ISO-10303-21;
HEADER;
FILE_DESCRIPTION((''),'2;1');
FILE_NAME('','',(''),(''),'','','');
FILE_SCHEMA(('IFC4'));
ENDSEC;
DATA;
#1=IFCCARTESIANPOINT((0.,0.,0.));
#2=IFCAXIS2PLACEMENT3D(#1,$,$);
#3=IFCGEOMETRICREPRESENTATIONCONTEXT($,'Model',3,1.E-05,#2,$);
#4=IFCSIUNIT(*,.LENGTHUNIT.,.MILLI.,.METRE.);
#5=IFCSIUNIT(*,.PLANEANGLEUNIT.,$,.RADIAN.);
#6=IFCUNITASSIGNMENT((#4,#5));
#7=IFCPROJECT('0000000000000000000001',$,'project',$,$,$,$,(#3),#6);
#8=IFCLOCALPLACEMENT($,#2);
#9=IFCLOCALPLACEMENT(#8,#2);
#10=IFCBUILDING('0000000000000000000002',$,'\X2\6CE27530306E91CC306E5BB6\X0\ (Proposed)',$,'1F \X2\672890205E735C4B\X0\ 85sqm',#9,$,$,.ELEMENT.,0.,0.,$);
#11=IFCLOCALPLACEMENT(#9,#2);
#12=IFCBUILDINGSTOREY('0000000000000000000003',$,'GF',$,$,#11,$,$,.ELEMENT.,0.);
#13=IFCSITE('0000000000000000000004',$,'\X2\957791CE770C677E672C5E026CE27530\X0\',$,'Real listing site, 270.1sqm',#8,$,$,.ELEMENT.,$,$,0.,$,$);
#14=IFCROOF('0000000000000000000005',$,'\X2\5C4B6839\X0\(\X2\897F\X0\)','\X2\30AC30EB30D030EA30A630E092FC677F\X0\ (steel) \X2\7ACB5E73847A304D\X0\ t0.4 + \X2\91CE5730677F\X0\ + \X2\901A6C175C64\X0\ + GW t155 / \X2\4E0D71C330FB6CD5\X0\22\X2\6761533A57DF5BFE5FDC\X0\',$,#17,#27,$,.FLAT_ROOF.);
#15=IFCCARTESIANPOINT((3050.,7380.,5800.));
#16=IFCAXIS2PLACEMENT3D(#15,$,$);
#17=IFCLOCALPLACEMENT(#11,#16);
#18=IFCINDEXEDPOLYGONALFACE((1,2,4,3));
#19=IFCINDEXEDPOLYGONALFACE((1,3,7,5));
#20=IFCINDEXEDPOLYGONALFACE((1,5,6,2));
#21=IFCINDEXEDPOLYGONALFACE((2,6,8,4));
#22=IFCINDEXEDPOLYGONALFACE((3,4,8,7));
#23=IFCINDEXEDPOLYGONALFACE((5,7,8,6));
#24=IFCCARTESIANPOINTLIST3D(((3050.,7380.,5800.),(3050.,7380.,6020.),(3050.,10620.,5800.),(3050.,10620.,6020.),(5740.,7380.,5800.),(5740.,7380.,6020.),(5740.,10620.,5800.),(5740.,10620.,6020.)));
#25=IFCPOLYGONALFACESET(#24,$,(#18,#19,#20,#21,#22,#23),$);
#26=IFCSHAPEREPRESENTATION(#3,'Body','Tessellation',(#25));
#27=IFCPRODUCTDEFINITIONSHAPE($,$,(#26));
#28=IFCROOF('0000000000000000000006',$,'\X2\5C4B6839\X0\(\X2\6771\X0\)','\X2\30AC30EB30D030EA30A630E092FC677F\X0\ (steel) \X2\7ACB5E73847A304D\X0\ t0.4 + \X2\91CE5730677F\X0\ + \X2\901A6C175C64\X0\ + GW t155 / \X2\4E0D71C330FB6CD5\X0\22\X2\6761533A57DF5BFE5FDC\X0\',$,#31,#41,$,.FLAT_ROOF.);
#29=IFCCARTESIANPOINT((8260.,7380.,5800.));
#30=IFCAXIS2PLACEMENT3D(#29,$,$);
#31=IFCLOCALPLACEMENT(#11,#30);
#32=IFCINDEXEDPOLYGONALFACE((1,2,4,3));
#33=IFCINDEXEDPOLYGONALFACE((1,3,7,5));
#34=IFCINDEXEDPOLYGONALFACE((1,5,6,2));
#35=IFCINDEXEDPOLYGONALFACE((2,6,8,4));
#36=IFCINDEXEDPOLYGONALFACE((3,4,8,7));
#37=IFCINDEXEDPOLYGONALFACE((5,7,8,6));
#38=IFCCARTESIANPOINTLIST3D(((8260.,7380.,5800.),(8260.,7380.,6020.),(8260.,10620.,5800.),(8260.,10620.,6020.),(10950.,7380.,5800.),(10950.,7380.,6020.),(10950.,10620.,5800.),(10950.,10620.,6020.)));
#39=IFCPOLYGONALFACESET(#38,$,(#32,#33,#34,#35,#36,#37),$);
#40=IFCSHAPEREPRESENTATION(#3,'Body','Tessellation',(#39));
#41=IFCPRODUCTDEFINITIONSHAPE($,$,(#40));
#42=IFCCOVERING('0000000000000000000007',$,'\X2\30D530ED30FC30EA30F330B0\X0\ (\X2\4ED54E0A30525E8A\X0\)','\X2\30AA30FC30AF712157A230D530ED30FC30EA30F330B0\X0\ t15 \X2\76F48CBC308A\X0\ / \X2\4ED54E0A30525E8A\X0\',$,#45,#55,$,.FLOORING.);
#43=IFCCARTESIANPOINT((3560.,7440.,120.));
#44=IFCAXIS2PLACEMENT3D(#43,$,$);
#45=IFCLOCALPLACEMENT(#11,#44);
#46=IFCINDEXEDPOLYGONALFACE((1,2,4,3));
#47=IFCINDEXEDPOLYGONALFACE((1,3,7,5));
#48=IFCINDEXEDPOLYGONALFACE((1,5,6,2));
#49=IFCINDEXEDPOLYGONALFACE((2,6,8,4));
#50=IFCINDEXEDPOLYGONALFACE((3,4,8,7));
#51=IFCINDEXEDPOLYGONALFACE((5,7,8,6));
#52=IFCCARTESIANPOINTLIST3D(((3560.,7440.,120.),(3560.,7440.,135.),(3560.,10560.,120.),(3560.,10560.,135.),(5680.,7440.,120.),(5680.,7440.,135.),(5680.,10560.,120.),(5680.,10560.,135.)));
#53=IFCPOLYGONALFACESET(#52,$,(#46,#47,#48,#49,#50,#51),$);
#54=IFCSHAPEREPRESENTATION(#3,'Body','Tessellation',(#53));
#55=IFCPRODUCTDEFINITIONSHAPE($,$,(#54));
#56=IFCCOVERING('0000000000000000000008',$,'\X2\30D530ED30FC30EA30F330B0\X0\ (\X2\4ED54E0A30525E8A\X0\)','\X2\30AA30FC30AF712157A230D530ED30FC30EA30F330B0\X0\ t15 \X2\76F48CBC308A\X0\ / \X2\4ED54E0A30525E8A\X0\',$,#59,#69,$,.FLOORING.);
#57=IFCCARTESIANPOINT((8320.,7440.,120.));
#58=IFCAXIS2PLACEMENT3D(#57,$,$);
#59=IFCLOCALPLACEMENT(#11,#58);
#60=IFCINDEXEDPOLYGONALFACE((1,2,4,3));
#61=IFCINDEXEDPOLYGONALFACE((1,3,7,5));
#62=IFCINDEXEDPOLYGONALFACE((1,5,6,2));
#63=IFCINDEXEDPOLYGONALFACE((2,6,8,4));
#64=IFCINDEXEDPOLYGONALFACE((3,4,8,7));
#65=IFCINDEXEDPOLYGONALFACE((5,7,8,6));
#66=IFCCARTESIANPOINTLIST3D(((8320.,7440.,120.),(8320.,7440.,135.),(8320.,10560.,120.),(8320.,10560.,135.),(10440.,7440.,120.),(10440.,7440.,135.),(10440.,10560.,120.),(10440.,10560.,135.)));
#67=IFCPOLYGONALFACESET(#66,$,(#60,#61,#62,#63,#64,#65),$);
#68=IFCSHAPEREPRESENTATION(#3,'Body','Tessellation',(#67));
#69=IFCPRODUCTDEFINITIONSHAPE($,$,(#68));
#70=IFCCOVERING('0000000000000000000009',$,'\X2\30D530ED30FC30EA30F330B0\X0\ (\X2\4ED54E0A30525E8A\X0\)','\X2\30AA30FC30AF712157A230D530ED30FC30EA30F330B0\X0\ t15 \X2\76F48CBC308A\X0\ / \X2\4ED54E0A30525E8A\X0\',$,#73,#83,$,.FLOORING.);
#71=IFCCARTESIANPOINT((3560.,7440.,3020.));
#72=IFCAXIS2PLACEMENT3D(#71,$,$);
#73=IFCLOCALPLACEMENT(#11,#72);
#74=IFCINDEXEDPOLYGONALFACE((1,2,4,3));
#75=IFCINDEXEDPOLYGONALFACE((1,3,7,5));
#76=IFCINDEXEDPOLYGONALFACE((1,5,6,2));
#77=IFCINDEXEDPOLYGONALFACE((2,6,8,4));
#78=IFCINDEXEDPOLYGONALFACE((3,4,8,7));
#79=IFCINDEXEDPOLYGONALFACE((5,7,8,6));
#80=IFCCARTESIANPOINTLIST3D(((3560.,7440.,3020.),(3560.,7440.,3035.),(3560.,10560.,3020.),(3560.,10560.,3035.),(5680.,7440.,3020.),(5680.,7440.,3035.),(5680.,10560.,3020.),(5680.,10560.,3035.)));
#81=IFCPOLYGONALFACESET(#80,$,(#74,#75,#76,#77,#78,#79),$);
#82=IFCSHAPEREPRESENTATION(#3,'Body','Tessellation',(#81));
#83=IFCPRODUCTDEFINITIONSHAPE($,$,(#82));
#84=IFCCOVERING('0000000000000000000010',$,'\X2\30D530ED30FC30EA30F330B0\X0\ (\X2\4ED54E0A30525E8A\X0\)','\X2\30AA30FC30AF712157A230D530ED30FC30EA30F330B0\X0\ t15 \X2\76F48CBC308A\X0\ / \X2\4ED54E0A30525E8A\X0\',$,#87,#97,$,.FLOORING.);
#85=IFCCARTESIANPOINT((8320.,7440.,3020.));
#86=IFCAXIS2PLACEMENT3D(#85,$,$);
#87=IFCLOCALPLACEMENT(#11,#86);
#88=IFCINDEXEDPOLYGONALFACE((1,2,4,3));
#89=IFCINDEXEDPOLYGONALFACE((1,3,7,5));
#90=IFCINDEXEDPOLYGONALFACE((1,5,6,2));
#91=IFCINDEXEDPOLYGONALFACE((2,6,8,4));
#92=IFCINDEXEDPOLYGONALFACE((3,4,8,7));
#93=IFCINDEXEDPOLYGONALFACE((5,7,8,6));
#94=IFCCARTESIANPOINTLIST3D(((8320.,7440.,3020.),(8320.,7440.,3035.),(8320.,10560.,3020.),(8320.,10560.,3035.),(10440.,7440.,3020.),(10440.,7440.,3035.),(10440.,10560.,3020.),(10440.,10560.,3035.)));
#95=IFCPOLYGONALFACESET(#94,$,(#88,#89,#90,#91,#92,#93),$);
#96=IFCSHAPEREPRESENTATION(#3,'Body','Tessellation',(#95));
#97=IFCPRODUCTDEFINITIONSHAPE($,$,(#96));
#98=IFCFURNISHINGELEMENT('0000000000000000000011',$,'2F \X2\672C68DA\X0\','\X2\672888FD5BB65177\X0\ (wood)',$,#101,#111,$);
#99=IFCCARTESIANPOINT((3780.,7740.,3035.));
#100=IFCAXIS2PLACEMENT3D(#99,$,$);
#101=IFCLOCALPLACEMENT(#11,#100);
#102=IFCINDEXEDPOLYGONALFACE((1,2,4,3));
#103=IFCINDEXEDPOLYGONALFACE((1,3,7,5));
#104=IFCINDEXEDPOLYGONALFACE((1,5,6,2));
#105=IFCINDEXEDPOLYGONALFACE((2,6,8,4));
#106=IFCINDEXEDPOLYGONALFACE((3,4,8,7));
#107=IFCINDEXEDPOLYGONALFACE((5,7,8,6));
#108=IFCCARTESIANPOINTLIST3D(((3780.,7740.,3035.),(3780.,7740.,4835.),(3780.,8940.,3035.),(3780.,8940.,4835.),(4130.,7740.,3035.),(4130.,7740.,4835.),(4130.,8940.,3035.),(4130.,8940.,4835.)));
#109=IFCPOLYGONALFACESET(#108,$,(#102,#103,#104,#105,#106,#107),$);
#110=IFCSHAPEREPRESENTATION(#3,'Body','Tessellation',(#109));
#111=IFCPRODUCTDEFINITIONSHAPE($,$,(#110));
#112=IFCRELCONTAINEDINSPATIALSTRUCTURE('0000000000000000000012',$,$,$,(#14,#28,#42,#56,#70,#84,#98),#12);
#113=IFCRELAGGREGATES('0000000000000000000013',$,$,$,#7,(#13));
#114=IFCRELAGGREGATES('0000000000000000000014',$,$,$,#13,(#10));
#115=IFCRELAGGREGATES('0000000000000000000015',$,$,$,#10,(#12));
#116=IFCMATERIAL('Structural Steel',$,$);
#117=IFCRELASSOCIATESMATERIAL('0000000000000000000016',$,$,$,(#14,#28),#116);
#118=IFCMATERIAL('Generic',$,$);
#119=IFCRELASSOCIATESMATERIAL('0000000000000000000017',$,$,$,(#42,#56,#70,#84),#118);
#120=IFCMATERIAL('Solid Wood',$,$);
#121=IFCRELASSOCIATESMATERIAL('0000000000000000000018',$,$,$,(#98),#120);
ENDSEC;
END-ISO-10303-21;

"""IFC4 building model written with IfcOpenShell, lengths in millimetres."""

from ifc_helpers import new_model, si_unit, frame, frame_2d, origin, place, context, project, spatial, rectangle, extrude, material, element, save


model = new_model("IFC4")

# Units and contexts
model_context = context("Model", 3, precision=1e-05, world=origin())
ifc_project = project(units=[si_unit("LENGTHUNIT", "METRE", prefix="MILLI"), si_unit("PLANEANGLEUNIT", "RADIAN")], contexts=[model_context])

# Site, building, storey
site_placement = place(None, origin())
site = spatial("IfcSite", under=ifc_project, at=site_placement, Name="長野県松本市波田", ObjectType="Real listing site, 270.1sqm", CompositionType="ELEMENT", RefElevation=0.0)
building_placement = place(site_placement, origin())
building = spatial("IfcBuilding", under=site, at=building_placement, Name="波田の里の家 (Proposed)", ObjectType="1F 木造平屋 85sqm", CompositionType="ELEMENT", ElevationOfRefHeight=0.0, ElevationOfTerrain=0.0)
storey_placement = place(building_placement, origin())
storey = spatial("IfcBuildingStorey", under=building, at=storey_placement, Name="GF", CompositionType="ELEMENT", Elevation=0.0)

# Shared definitions
ifc_material_1 = material(Name="Solid Wood")

# Shared definitions
ifc_material_2 = material(Name="Generic")

# Roofs
ifc_material_3 = material(Name="Structural Steel")
roof_1_placement = place(storey_placement, frame((3050.0, 7380.0, 5800.0)))
element("IfcRoof", 1, at=roof_1_placement, inside=storey, material=ifc_material_3, Name="屋根(西)", Description="ガルバリウム鋼板 (steel) 立平葺き t0.4 + 野地板 + 通気層 + GW t155 / 不燃・法22条区域対応", PredefinedType="FLAT_ROOF", context=model_context, shape_type="SweptSolid", body=[
    extrude(rectangle(XDim=2690.0, YDim=3240.0, at=frame_2d((1345.0, 1620.0))), frame((3050.0, 7380.0, 5800.0)), (0.0, 0.0, 1.0), 220.0),
])
roof_2_placement = place(storey_placement, frame((8260.0, 7380.0, 5800.0)))
element("IfcRoof", 2, at=roof_2_placement, inside=storey, material=ifc_material_3, Name="屋根(東)", Description="ガルバリウム鋼板 (steel) 立平葺き t0.4 + 野地板 + 通気層 + GW t155 / 不燃・法22条区域対応", PredefinedType="FLAT_ROOF", context=model_context, shape_type="SweptSolid", body=[
    extrude(rectangle(XDim=2690.0, YDim=3240.0, at=frame_2d((1345.0, 1620.0))), frame((8260.0, 7380.0, 5800.0)), (0.0, 0.0, 1.0), 220.0),
])

# Coverings
covering_1_placement = place(storey_placement, frame((3560.0, 7440.0, 120.0)))
element("IfcCovering", 3, at=covering_1_placement, inside=storey, material=ifc_material_2, Name="フローリング (仕上げ床)", Description="オーク無垢フローリング t15 直貼り / 仕上げ床", PredefinedType="FLOORING", context=model_context, shape_type="SweptSolid", body=[
    extrude(rectangle(XDim=2120.0, YDim=3120.0, at=frame_2d((1060.0, 1560.0))), frame((3560.0, 7440.0, 120.0)), (0.0, 0.0, 1.0), 15.0),
])
covering_2_placement = place(storey_placement, frame((8320.0, 7440.0, 120.0)))
element("IfcCovering", 4, at=covering_2_placement, inside=storey, material=ifc_material_2, Name="フローリング (仕上げ床)", Description="オーク無垢フローリング t15 直貼り / 仕上げ床", PredefinedType="FLOORING", context=model_context, shape_type="SweptSolid", body=[
    extrude(rectangle(XDim=2120.0, YDim=3120.0, at=frame_2d((1060.0, 1560.0))), frame((8320.0, 7440.0, 120.0)), (0.0, 0.0, 1.0), 15.0),
])
covering_3_placement = place(storey_placement, frame((3560.0, 7440.0, 3020.0)))
element("IfcCovering", 5, at=covering_3_placement, inside=storey, material=ifc_material_2, Name="フローリング (仕上げ床)", Description="オーク無垢フローリング t15 直貼り / 仕上げ床", PredefinedType="FLOORING", context=model_context, shape_type="SweptSolid", body=[
    extrude(rectangle(XDim=2120.0, YDim=3120.0, at=frame_2d((1060.0, 1560.0))), frame((3560.0, 7440.0, 3020.0)), (0.0, 0.0, 1.0), 15.0),
])
covering_4_placement = place(storey_placement, frame((8320.0, 7440.0, 3020.0)))
element("IfcCovering", 6, at=covering_4_placement, inside=storey, material=ifc_material_2, Name="フローリング (仕上げ床)", Description="オーク無垢フローリング t15 直貼り / 仕上げ床", PredefinedType="FLOORING", context=model_context, shape_type="SweptSolid", body=[
    extrude(rectangle(XDim=2120.0, YDim=3120.0, at=frame_2d((1060.0, 1560.0))), frame((8320.0, 7440.0, 3020.0)), (0.0, 0.0, 1.0), 15.0),
])

# Furnishing element
furnishing_placement = place(storey_placement, frame((3780.0, 7740.0, 3035.0)))
element("IfcFurnishingElement", 7, at=furnishing_placement, inside=storey, material=ifc_material_1, Name="2F 本棚", Description="木製家具 (wood)", context=model_context, shape_type="SweptSolid", body=[
    extrude(rectangle(XDim=350.0, YDim=1200.0, at=frame_2d((175.0, 600.0))), frame((3780.0, 7740.0, 3035.0)), (0.0, 0.0, 1.0), 1800.0),
])

save(model, "model.ifc")
